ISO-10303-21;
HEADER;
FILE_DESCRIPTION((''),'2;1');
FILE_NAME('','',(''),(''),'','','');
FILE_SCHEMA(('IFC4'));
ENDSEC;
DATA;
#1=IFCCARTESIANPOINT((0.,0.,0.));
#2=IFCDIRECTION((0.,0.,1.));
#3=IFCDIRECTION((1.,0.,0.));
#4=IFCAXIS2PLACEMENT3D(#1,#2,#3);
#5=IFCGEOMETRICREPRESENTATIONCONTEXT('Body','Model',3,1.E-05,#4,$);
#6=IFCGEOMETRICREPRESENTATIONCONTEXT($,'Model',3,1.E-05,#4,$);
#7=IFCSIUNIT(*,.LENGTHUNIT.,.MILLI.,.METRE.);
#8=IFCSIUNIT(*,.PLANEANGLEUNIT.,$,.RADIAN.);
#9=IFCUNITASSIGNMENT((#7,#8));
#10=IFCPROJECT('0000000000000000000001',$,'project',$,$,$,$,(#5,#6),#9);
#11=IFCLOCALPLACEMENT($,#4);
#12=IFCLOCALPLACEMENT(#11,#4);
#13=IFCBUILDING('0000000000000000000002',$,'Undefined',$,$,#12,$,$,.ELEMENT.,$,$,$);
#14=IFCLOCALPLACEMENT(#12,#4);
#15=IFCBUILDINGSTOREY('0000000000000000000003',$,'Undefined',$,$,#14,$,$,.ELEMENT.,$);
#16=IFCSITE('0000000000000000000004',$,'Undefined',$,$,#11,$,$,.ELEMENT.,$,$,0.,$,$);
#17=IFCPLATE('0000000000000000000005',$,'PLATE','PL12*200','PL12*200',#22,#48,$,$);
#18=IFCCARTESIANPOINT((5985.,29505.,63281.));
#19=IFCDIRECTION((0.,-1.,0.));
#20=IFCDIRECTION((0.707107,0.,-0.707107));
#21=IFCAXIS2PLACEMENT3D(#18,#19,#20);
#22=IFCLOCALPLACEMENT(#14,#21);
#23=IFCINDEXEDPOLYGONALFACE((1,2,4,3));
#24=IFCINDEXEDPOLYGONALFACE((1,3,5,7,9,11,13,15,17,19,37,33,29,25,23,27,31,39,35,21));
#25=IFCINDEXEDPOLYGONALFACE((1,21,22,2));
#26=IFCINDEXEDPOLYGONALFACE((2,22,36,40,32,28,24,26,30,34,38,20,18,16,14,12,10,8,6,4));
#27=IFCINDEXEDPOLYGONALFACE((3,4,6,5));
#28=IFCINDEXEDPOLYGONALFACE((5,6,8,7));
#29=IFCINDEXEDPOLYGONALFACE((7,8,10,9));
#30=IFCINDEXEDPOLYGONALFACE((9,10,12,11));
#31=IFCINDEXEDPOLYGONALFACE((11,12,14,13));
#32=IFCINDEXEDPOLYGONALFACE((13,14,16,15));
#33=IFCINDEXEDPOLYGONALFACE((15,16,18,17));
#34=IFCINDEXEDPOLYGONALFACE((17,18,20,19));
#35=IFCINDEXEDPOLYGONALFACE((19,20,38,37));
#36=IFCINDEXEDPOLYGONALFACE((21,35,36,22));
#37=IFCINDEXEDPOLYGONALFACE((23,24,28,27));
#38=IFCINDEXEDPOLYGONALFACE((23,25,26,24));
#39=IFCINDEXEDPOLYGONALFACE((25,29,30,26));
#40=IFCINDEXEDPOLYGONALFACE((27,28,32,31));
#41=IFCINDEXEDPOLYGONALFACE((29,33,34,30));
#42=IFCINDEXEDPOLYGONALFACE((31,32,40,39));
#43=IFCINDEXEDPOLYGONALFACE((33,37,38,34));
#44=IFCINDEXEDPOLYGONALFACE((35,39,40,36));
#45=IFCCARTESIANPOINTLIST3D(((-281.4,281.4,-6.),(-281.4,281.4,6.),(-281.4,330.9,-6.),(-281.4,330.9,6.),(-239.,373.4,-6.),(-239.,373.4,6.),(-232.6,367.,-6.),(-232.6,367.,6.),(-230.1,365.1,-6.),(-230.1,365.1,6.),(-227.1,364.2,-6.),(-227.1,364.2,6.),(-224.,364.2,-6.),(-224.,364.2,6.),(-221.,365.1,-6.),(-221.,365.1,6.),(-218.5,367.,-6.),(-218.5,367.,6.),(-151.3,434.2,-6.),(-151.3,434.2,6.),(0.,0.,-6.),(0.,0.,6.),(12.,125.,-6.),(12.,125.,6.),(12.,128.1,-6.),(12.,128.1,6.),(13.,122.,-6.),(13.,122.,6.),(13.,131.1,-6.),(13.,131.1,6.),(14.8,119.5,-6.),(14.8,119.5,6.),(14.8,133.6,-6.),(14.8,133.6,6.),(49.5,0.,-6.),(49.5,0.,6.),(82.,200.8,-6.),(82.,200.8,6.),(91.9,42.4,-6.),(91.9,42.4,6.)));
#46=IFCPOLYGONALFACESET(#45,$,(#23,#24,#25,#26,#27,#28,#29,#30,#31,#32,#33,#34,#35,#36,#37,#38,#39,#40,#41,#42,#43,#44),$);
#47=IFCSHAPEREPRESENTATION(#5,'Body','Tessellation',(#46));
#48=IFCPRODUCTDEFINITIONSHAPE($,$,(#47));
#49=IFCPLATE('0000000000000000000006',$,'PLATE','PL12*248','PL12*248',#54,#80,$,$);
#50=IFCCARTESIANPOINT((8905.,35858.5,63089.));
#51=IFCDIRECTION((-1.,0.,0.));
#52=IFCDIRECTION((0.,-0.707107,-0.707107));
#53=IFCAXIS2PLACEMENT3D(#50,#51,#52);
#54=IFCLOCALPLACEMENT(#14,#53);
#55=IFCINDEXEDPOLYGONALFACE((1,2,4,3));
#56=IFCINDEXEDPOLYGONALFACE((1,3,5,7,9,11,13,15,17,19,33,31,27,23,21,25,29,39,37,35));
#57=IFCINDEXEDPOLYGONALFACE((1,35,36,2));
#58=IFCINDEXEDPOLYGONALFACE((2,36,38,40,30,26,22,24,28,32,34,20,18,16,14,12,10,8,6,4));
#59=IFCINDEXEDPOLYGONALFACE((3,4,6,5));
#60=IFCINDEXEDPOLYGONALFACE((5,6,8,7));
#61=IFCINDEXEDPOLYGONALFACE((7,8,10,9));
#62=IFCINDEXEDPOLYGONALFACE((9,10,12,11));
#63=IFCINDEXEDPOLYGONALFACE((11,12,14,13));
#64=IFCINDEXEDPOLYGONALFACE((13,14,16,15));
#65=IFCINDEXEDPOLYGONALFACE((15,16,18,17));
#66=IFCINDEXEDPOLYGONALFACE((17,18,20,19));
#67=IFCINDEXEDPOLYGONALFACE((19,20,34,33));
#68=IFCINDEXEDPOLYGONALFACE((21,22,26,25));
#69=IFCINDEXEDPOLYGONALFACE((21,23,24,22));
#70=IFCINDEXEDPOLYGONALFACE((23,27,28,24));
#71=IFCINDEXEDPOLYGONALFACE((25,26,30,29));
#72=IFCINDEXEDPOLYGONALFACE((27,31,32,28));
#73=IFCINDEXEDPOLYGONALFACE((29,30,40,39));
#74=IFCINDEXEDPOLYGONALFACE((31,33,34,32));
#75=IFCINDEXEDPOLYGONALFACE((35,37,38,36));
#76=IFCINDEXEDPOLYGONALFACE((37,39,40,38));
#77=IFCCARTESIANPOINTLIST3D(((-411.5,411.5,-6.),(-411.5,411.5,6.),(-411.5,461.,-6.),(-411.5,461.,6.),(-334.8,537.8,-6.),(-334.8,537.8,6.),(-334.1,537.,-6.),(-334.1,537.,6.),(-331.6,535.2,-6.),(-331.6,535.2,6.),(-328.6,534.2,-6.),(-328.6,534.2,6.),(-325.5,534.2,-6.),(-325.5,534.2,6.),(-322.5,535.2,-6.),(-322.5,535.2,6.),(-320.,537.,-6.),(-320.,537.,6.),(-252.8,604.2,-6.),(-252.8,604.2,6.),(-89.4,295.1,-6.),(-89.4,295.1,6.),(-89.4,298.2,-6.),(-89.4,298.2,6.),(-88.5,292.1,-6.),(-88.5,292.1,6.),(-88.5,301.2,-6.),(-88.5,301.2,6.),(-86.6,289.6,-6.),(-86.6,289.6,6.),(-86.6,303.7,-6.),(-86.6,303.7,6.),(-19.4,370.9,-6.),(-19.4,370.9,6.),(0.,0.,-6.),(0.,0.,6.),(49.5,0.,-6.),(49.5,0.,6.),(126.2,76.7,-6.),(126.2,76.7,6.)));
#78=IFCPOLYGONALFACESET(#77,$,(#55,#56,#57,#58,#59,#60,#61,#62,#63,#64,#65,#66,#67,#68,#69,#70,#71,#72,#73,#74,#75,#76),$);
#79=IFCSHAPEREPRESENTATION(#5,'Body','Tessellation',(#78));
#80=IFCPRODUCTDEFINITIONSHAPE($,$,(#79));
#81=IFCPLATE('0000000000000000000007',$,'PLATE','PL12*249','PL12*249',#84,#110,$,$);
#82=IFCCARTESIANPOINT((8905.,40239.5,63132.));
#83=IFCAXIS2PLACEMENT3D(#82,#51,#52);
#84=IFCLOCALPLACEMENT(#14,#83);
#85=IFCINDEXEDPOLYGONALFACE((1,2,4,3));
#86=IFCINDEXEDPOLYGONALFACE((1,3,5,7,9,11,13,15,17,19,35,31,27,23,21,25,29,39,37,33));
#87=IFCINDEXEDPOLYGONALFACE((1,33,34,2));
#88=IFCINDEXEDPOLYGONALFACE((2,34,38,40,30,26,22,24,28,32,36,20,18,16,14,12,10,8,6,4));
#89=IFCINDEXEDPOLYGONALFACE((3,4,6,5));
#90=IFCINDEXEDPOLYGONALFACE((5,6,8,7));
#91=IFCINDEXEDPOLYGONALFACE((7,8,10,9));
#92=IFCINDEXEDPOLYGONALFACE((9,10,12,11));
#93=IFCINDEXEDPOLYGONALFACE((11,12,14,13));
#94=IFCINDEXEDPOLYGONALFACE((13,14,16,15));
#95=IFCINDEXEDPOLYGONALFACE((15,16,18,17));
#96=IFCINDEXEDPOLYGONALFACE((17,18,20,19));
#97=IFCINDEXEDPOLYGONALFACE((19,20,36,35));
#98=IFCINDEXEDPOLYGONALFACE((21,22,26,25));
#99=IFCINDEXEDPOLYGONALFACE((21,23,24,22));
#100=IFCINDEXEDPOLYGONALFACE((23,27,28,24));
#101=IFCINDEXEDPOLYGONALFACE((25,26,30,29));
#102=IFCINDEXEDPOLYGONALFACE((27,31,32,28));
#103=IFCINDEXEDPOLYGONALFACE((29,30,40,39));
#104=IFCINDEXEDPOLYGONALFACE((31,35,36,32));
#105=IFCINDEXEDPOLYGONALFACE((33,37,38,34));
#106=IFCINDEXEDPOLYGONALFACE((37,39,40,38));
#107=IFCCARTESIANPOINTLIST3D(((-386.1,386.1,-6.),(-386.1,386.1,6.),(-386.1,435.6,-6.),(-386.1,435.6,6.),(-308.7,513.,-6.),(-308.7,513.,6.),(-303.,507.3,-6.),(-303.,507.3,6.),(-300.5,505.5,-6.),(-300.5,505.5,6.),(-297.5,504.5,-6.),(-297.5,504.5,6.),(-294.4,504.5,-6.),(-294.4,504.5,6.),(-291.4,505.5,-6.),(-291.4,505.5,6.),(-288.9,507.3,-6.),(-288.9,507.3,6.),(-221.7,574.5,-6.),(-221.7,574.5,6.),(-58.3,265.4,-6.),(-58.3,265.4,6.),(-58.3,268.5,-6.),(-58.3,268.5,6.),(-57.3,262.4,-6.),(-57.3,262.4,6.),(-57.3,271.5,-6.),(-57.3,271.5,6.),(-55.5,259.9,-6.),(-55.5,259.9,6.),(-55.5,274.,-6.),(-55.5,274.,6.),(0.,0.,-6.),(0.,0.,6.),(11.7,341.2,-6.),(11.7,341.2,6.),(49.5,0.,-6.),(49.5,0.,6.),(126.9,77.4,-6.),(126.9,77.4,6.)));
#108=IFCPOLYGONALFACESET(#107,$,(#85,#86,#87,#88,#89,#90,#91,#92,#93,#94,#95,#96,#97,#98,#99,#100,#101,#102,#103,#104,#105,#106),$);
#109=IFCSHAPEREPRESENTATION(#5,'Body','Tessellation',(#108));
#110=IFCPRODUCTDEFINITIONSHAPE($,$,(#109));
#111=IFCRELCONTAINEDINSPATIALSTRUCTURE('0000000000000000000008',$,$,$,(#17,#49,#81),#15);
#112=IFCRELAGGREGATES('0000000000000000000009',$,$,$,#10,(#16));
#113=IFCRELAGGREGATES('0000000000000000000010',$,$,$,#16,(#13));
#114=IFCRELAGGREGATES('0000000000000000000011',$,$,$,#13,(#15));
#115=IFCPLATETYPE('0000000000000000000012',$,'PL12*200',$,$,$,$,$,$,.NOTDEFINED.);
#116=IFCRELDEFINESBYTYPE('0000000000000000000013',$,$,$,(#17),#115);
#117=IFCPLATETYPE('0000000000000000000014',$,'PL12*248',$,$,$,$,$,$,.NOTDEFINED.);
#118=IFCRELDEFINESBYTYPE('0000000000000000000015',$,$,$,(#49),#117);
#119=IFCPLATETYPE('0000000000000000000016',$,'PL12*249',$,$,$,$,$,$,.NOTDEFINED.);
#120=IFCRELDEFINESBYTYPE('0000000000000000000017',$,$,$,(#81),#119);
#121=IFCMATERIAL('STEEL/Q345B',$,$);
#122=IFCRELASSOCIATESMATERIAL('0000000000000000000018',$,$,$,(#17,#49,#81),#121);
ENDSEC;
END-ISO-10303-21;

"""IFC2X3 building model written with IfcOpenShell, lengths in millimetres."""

from ifc_helpers import new_model, si_unit, frame, origin_with_axes, place, context, project, spatial, polyline, outline, extrude, material, type_object, element, save


model = new_model("IFC2X3")

# Units and contexts
model_context_1 = context("Model", 3, precision=1e-05, world=origin_with_axes(), identifier="Body")
model_context_2 = context("Model", 3, precision=1e-05, world=origin_with_axes())
ifc_project = project(units=[si_unit("LENGTHUNIT", "METRE", prefix="MILLI"), si_unit("PLANEANGLEUNIT", "RADIAN")], contexts=[model_context_1, model_context_2])

# Site, building, storey
site_placement = place(None, origin_with_axes())
site = spatial("IfcSite", under=ifc_project, at=site_placement, Name="Undefined", CompositionType="ELEMENT", RefElevation=0.0)
building_placement = place(site_placement, origin_with_axes())
building = spatial("IfcBuilding", under=site, at=building_placement, Name="Undefined", CompositionType="ELEMENT")
storey_placement = place(building_placement, origin_with_axes())
storey = spatial("IfcBuildingStorey", under=building, at=storey_placement, Name="Undefined", CompositionType="ELEMENT")

# Shared definitions
ifc_material_1 = material(Name="STEEL/Q345B")

# Plates
plate_type_1 = type_object("IfcPlateType", Name="PL12*200", PredefinedType="NOTDEFINED")
for number, where, z_axis, x_axis, name in (
    (1, (5985.0, 29505.0, 63281.0), (0.0, -1.0, 0.0), (0.707107, 0.0, -0.707107), "PLATE"),
):
    element("IfcPlate", number, at=place(storey_placement, frame(where, z_axis=z_axis, x_axis=x_axis)), inside=storey, type_object=plate_type_1, material=ifc_material_1, Name=name, Description="PL12*200", ObjectType="PL12*200", context=model_context_1, shape_type="SweptSolid", body=[
        extrude(outline(polyline([(0.0, 0.0), (49.5, 0.0), (91.9, 42.4), (14.8, 119.5), (13.0, 122.0), (12.0, 125.0), (12.0, 128.1), (13.0, 131.1), (14.8, 133.6), (82.0, 200.8), (-151.3, 434.2), (-218.5, 367.0), (-221.0, 365.1), (-224.0, 364.2), (-227.1, 364.2), (-230.1, 365.1), (-232.6, 367.0), (-239.0, 373.4), (-281.4, 330.9), (-281.4, 281.4), (0.0, 0.0)])), frame((0.0, 0.0, -6.0), z_axis=(0.0, 0.0, 1.0), x_axis=(1.0, 0.0, 0.0)), (0.0, 0.0, 1.0), 12.0),
    ])
plate_type_2 = type_object("IfcPlateType", Name="PL12*248", PredefinedType="NOTDEFINED")
plate_1_placement = place(storey_placement, frame((8905.0, 35858.5, 63089.0), z_axis=(-1.0, 0.0, 0.0), x_axis=(0.0, -0.707107, -0.707107)))
element("IfcPlate", 2, at=plate_1_placement, inside=storey, type_object=plate_type_2, material=ifc_material_1, Name="PLATE", Description="PL12*248", ObjectType="PL12*248", context=model_context_1, shape_type="SweptSolid", body=[
    extrude(outline(polyline([(0.0, 0.0), (49.5, 0.0), (126.2, 76.7), (-86.6, 289.6), (-88.5, 292.1), (-89.4, 295.1), (-89.4, 298.2), (-88.5, 301.2), (-86.6, 303.7), (-19.4, 370.9), (-252.8, 604.2), (-320.0, 537.0), (-322.5, 535.2), (-325.5, 534.2), (-328.6, 534.2), (-331.6, 535.2), (-334.1, 537.0), (-334.8, 537.8), (-411.5, 461.0), (-411.5, 411.5), (0.0, 0.0)])), frame((0.0, 0.0, -6.0), z_axis=(0.0, 0.0, 1.0), x_axis=(1.0, 0.0, 0.0)), (0.0, 0.0, 1.0), 12.0),
])
plate_type_3 = type_object("IfcPlateType", Name="PL12*249", PredefinedType="NOTDEFINED")
for number, where, z_axis, x_axis, name in (
    (3, (8905.0, 40239.5, 63132.0), (-1.0, 0.0, 0.0), (0.0, -0.707107, -0.707107), "PLATE"),
):
    element("IfcPlate", number, at=place(storey_placement, frame(where, z_axis=z_axis, x_axis=x_axis)), inside=storey, type_object=plate_type_3, material=ifc_material_1, Name=name, Description="PL12*249", ObjectType="PL12*249", context=model_context_1, shape_type="SweptSolid", body=[
        extrude(outline(polyline([(0.0, 0.0), (49.5, 0.0), (126.9, 77.4), (-55.5, 259.9), (-57.3, 262.4), (-58.3, 265.4), (-58.3, 268.5), (-57.3, 271.5), (-55.5, 274.0), (11.7, 341.2), (-221.7, 574.5), (-288.9, 507.3), (-291.4, 505.5), (-294.4, 504.5), (-297.5, 504.5), (-300.5, 505.5), (-303.0, 507.3), (-308.7, 513.0), (-386.1, 435.6), (-386.1, 386.1), (0.0, 0.0)])), frame((0.0, 0.0, -6.0), z_axis=(0.0, 0.0, 1.0), x_axis=(1.0, 0.0, 0.0)), (0.0, 0.0, 1.0), 12.0),
    ])

save(model, "model.ifc")
